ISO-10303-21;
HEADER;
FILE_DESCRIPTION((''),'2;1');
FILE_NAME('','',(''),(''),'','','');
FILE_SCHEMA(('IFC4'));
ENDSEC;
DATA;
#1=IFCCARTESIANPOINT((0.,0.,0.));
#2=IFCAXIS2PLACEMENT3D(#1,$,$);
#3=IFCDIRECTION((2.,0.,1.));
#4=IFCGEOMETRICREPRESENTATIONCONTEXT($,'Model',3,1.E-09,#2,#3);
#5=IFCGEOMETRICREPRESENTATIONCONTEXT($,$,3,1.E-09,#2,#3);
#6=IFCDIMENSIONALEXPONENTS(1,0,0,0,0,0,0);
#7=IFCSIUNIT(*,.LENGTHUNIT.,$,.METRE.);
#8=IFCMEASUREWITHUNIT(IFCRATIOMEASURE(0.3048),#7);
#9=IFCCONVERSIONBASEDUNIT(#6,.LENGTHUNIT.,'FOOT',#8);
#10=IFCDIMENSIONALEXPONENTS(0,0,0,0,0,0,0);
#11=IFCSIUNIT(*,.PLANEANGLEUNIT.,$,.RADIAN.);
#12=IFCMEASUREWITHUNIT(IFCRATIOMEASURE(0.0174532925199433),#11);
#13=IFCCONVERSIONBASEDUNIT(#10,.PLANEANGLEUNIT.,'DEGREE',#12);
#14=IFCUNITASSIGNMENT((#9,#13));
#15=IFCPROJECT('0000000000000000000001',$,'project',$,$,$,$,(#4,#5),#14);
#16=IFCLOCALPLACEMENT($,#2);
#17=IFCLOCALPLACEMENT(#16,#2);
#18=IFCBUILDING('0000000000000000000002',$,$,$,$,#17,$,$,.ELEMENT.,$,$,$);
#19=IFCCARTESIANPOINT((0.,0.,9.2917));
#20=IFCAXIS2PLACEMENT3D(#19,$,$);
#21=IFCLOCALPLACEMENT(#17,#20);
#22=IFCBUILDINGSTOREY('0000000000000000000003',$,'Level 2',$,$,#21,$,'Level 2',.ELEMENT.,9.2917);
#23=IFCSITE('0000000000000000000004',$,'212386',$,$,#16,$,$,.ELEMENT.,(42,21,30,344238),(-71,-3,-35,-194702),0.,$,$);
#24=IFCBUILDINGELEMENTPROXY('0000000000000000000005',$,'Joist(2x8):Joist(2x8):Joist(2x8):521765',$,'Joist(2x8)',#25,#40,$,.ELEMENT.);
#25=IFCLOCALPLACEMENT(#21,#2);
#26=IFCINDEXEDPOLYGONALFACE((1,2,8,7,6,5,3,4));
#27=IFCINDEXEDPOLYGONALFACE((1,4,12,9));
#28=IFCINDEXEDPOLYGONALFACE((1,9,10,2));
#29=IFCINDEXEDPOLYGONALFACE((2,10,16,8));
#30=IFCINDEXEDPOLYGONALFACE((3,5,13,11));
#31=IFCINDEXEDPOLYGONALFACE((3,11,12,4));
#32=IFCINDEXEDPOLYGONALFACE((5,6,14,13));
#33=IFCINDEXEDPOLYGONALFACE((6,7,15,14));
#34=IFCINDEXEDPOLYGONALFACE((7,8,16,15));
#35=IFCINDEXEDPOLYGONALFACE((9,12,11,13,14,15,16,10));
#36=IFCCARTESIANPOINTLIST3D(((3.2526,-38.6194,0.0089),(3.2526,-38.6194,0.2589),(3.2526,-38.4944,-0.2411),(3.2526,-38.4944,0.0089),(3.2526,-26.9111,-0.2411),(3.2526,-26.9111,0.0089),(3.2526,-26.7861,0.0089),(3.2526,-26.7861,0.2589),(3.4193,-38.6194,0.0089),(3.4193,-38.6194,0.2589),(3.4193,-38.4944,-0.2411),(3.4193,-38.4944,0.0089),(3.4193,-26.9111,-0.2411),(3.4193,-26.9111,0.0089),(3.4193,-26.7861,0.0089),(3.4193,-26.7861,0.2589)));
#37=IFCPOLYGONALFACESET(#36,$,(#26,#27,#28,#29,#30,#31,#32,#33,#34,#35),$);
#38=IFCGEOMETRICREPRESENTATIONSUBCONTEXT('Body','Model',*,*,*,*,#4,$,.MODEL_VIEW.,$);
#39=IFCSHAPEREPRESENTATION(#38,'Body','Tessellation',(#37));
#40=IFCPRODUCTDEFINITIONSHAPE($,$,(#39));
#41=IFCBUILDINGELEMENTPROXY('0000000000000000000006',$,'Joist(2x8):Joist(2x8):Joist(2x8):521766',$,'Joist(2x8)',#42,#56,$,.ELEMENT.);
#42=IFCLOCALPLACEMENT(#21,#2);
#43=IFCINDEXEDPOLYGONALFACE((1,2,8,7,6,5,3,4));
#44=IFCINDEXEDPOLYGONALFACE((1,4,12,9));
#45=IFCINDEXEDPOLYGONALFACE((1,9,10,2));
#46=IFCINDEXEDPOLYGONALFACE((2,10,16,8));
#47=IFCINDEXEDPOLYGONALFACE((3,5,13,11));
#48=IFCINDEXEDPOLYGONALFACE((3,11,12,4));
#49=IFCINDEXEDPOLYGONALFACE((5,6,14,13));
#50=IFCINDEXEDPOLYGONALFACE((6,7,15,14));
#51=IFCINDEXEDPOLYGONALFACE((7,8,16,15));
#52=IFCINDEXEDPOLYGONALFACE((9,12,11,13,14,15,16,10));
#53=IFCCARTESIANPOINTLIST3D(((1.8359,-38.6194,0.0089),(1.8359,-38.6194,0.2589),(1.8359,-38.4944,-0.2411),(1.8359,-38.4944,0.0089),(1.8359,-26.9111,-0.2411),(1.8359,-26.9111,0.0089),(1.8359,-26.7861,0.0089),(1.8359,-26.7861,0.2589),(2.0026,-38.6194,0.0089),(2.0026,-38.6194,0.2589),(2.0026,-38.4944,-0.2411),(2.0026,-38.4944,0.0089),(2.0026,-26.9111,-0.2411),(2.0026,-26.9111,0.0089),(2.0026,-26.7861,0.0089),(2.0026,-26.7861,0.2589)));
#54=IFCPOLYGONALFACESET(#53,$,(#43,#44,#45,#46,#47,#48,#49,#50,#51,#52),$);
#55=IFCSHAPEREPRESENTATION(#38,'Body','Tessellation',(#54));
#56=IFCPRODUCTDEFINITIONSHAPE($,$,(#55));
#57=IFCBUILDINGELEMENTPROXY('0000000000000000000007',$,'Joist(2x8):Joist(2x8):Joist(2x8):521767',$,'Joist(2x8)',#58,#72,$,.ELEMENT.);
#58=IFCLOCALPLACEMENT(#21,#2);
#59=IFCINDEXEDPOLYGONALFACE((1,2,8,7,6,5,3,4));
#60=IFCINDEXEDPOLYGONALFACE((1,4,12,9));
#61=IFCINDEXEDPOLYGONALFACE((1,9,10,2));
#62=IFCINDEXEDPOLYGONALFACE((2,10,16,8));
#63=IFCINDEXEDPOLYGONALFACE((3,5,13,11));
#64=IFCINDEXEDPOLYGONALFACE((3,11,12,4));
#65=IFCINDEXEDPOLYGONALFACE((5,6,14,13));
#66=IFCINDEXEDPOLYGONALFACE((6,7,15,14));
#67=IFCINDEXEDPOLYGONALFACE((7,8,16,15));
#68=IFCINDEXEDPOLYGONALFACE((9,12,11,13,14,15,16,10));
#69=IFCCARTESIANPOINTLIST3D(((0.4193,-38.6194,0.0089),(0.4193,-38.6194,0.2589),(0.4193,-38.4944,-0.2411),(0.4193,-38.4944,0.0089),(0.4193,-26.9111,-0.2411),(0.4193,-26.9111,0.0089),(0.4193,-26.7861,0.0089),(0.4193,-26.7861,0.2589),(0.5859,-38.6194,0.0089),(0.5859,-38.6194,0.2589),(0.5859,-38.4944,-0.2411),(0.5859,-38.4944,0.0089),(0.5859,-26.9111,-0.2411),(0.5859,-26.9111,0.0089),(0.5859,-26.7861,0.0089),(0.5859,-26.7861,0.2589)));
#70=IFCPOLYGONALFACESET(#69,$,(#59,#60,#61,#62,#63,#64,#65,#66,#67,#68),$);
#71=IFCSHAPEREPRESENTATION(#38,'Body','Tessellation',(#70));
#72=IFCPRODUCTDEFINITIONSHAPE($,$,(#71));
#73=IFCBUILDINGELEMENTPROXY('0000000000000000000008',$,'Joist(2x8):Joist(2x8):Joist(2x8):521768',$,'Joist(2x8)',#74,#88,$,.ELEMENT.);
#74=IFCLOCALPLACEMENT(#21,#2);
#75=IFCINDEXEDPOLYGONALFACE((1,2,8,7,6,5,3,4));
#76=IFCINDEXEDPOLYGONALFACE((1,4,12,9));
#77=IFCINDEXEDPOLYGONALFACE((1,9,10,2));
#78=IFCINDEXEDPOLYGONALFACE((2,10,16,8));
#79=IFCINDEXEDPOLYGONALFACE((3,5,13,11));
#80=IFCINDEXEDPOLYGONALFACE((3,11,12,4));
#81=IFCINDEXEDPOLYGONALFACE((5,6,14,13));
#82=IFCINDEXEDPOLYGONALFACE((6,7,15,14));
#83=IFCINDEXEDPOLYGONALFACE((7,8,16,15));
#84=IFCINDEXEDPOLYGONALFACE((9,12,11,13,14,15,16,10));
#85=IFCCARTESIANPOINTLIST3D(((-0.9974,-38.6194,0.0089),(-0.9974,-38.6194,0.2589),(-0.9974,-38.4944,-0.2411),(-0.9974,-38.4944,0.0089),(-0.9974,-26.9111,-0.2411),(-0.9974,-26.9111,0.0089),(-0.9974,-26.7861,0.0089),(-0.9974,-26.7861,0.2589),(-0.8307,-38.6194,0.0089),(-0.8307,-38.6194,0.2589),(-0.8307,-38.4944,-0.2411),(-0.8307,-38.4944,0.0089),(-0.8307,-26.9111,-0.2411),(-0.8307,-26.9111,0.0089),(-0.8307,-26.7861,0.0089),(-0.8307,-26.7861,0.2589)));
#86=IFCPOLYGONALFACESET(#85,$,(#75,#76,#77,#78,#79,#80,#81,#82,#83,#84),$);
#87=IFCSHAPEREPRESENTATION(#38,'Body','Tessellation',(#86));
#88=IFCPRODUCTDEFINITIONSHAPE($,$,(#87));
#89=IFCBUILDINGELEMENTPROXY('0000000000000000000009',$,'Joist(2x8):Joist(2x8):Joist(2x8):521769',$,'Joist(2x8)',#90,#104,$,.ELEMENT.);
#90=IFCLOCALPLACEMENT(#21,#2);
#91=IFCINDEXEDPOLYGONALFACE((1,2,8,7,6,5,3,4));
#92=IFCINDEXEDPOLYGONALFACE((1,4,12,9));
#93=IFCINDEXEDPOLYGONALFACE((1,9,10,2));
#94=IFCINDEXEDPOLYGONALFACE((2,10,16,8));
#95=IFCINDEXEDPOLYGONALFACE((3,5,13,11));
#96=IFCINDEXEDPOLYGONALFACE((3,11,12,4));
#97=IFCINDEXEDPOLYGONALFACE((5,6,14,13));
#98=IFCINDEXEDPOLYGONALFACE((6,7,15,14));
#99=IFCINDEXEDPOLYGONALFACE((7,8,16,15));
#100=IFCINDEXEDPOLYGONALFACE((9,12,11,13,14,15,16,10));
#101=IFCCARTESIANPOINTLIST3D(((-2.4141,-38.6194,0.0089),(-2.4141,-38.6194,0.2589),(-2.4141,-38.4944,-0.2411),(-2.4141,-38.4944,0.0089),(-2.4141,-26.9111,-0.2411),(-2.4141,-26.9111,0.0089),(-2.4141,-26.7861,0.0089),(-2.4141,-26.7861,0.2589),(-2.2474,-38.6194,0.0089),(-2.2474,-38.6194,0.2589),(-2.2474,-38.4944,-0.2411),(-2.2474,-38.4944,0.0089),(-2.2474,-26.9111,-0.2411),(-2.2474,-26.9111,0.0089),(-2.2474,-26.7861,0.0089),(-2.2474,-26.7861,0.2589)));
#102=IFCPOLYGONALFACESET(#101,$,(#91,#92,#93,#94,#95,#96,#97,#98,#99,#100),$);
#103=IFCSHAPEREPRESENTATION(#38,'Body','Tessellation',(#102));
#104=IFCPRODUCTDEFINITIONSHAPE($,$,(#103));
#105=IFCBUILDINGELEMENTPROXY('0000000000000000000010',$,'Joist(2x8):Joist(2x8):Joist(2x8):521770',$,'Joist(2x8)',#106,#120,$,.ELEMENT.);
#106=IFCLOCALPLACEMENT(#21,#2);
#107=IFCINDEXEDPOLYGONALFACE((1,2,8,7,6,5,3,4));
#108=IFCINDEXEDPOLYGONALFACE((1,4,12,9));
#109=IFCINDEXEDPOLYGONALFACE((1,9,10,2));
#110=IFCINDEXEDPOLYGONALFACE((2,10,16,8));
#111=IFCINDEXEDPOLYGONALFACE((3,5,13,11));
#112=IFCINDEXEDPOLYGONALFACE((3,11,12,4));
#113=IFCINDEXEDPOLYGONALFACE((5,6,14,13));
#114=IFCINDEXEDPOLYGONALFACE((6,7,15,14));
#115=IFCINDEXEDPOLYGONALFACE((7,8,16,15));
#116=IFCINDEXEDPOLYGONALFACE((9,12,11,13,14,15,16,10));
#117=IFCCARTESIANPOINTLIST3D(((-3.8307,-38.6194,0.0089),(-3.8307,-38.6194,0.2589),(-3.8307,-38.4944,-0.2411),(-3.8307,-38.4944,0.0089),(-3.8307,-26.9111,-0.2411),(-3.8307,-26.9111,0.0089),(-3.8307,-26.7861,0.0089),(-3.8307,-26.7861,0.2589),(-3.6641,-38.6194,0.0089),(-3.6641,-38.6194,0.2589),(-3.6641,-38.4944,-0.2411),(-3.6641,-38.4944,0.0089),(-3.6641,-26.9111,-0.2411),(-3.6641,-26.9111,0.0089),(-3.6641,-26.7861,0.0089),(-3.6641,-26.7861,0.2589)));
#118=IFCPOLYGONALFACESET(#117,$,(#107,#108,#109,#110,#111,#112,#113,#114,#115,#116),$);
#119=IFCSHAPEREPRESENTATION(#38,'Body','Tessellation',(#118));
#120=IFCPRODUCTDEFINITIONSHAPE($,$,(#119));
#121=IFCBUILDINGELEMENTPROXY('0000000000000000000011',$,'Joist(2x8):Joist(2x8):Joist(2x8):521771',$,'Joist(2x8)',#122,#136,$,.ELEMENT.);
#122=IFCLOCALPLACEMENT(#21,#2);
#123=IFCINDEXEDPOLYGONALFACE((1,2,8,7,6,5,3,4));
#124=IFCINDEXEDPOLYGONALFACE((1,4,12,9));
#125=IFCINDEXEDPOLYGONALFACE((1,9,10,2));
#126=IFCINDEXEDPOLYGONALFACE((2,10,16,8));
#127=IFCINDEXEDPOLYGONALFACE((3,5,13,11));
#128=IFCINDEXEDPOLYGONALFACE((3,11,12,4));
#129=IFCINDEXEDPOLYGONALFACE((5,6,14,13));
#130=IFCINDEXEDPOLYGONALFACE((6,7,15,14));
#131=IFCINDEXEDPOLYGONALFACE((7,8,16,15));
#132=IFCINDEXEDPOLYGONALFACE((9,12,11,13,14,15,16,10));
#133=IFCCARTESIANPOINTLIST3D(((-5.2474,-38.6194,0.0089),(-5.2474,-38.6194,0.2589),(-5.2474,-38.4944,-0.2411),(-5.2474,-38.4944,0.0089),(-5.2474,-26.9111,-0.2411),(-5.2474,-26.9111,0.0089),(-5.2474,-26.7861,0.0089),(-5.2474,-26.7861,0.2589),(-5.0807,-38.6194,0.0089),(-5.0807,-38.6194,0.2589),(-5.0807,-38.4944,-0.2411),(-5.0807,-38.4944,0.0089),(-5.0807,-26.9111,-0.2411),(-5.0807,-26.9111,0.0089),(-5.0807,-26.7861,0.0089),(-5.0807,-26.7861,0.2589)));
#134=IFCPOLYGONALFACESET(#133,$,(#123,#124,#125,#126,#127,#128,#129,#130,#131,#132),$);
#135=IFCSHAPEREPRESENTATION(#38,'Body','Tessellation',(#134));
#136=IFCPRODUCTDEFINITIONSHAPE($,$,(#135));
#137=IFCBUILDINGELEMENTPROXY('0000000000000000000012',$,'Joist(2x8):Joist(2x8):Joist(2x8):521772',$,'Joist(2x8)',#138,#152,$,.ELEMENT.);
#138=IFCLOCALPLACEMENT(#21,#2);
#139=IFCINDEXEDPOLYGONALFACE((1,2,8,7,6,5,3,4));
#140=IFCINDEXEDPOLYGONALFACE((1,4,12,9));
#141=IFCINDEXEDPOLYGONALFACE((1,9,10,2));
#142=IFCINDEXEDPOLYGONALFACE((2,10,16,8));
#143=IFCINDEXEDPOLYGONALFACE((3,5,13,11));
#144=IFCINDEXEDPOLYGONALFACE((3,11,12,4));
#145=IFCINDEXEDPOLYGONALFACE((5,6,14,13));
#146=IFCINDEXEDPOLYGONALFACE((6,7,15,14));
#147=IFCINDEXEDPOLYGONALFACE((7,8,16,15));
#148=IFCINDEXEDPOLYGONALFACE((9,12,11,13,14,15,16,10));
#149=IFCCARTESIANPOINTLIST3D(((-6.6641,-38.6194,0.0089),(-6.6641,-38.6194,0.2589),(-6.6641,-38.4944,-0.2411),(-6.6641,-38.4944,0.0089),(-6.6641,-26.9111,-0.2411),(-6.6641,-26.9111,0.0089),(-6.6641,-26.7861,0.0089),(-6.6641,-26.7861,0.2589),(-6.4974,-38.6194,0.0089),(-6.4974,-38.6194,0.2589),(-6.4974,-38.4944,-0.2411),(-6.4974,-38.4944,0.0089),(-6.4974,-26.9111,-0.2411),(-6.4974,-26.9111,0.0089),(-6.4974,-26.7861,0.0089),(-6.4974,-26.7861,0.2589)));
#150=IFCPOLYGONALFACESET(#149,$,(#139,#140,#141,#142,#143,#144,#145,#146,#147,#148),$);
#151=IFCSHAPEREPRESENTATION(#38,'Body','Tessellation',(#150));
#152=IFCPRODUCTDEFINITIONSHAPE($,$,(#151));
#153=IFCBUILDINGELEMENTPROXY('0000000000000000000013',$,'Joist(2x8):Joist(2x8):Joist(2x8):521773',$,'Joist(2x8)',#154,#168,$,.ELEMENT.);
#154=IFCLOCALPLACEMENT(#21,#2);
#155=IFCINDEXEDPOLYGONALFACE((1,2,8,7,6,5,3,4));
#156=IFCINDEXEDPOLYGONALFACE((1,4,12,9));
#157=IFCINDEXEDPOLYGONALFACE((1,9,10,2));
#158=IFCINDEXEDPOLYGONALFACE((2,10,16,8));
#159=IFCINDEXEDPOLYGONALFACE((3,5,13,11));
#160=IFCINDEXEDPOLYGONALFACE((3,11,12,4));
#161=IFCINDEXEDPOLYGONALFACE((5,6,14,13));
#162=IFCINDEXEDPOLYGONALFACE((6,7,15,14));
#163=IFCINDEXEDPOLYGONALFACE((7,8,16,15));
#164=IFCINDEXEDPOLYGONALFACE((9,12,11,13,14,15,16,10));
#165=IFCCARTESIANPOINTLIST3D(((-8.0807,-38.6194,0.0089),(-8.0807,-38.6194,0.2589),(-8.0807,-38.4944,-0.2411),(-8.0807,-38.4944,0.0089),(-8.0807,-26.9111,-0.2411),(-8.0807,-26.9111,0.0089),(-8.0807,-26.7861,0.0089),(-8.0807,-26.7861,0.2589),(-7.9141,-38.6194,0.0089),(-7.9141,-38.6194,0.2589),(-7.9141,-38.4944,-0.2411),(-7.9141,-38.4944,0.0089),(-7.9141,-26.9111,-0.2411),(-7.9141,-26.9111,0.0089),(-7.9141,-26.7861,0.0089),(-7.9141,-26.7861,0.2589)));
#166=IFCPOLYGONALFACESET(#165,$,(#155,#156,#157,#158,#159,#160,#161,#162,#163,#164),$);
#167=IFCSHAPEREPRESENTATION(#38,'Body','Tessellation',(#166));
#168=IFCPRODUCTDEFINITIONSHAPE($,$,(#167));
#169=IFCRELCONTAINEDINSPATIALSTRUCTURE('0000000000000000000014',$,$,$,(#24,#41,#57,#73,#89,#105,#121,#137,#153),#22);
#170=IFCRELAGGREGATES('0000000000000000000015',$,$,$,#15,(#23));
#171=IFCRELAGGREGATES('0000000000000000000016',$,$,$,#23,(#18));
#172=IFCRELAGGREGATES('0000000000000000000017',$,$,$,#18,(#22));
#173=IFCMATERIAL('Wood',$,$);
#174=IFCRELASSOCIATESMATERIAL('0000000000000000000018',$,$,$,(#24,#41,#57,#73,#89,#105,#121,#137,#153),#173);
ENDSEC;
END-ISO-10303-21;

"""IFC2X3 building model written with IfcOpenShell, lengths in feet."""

from ifc_helpers import new_model, entity, si_unit, converted_unit, direction, frame, origin, place, context, subcontext, project, spatial, polyline, outline, extrude, source, transform, mapped, material, element, save


model = new_model("IFC2X3")

# Units and contexts
model_context = context("Model", 3, precision=1e-09, world=origin(), true_north=direction((2.0, 0.0, 1.0)))
context_of_model = context(None, 3, precision=1e-09, world=origin(), true_north=direction((2.0, 0.0, 1.0)))
body_context = subcontext(model_context, "Body", "Model", "MODEL_VIEW")
ifc_project = project(units=[converted_unit("LENGTHUNIT", "FOOT", entity("IfcRatioMeasure", 0.3048), si_unit("LENGTHUNIT", "METRE"), dimensions=[1, 0, 0, 0, 0, 0, 0]), converted_unit("PLANEANGLEUNIT", "DEGREE", entity("IfcRatioMeasure", 0.0174532925199433), si_unit("PLANEANGLEUNIT", "RADIAN"), dimensions=[0, 0, 0, 0, 0, 0, 0])], contexts=[model_context, context_of_model])

# Site, building, storey
site_placement = place(None, origin())
site = spatial("IfcSite", under=ifc_project, at=site_placement, Name="212386", CompositionType="ELEMENT", RefLatitude=(42, 21, 30, 344238), RefLongitude=(-71, -3, -35, -194702), RefElevation=0.0)
building_placement = place(site_placement, origin())
building = spatial("IfcBuilding", under=site, at=building_placement, CompositionType="ELEMENT")
storey_placement = place(building_placement, frame((0.0, 0.0, 9.2917)))
storey = spatial("IfcBuildingStorey", under=building, at=storey_placement, Name="Level 2", LongName="Level 2", CompositionType="ELEMENT", Elevation=9.2917)

# Building element proxies
ifc_material = material(Name="Wood")
shared_shape_1 = source(origin(), body_context, "Body", "SweptSolid", [
    extrude(outline(polyline([(-0.25, -5.9167), (0.0, -5.9167), (0.0, -5.7917), (0.25, -5.7917), (0.25, 5.7917), (0.0, 5.7917), (0.0, 5.9167), (-0.25, 5.9167), (-0.25, -5.9167)])), frame((3.2526, -32.7027, 9.3006), z_axis=(1.0, 0.0, 0.0), x_axis=(0.0, 0.0, -1.0)), (0.0, 0.0, 1.0), 0.1667),
])
proxy_1_placement = place(storey_placement, frame((0.0, 0.0, -9.2917)))
element("IfcBuildingElementProxy", 1, at=proxy_1_placement, inside=storey, material=ifc_material, Name="Joist(2x8):Joist(2x8):Joist(2x8):521765", ObjectType="Joist(2x8)", CompositionType="ELEMENT", context=body_context, shape_type="MappedRepresentation", body=[
    mapped(shared_shape_1, transform((0.0, 0.0, 0.0), scale=1.0)),
])
shared_shape_2 = source(origin(), body_context, "Body", "SweptSolid", [
    extrude(outline(polyline([(-0.25, -5.9167), (0.0, -5.9167), (0.0, -5.7917), (0.25, -5.7917), (0.25, 5.7917), (0.0, 5.7917), (0.0, 5.9167), (-0.25, 5.9167), (-0.25, -5.9167)])), frame((1.8359, -32.7027, 9.3006), z_axis=(1.0, 0.0, 0.0), x_axis=(0.0, 0.0, -1.0)), (0.0, 0.0, 1.0), 0.1667),
])
proxy_2_placement = place(storey_placement, frame((0.0, 0.0, -9.2917)))
element("IfcBuildingElementProxy", 2, at=proxy_2_placement, inside=storey, material=ifc_material, Name="Joist(2x8):Joist(2x8):Joist(2x8):521766", ObjectType="Joist(2x8)", CompositionType="ELEMENT", context=body_context, shape_type="MappedRepresentation", body=[
    mapped(shared_shape_2, transform((0.0, 0.0, 0.0), scale=1.0)),
])
shared_shape_3 = source(origin(), body_context, "Body", "SweptSolid", [
    extrude(outline(polyline([(-0.25, -5.9167), (0.0, -5.9167), (0.0, -5.7917), (0.25, -5.7917), (0.25, 5.7917), (0.0, 5.7917), (0.0, 5.9167), (-0.25, 5.9167), (-0.25, -5.9167)])), frame((0.4193, -32.7027, 9.3006), z_axis=(1.0, 0.0, 0.0), x_axis=(0.0, 0.0, -1.0)), (0.0, 0.0, 1.0), 0.1667),
])
proxy_3_placement = place(storey_placement, frame((0.0, 0.0, -9.2917)))
element("IfcBuildingElementProxy", 3, at=proxy_3_placement, inside=storey, material=ifc_material, Name="Joist(2x8):Joist(2x8):Joist(2x8):521767", ObjectType="Joist(2x8)", CompositionType="ELEMENT", context=body_context, shape_type="MappedRepresentation", body=[
    mapped(shared_shape_3, transform((0.0, 0.0, 0.0), scale=1.0)),
])
shared_shape_4 = source(origin(), body_context, "Body", "SweptSolid", [
    extrude(outline(polyline([(-0.25, -5.9167), (0.0, -5.9167), (0.0, -5.7917), (0.25, -5.7917), (0.25, 5.7917), (0.0, 5.7917), (0.0, 5.9167), (-0.25, 5.9167), (-0.25, -5.9167)])), frame((-0.9974, -32.7027, 9.3006), z_axis=(1.0, 0.0, 0.0), x_axis=(0.0, 0.0, -1.0)), (0.0, 0.0, 1.0), 0.1667),
])
proxy_4_placement = place(storey_placement, frame((0.0, 0.0, -9.2917)))
element("IfcBuildingElementProxy", 4, at=proxy_4_placement, inside=storey, material=ifc_material, Name="Joist(2x8):Joist(2x8):Joist(2x8):521768", ObjectType="Joist(2x8)", CompositionType="ELEMENT", context=body_context, shape_type="MappedRepresentation", body=[
    mapped(shared_shape_4, transform((0.0, 0.0, 0.0), scale=1.0)),
])
shared_shape_5 = source(origin(), body_context, "Body", "SweptSolid", [
    extrude(outline(polyline([(-0.25, -5.9167), (0.0, -5.9167), (0.0, -5.7917), (0.25, -5.7917), (0.25, 5.7917), (0.0, 5.7917), (0.0, 5.9167), (-0.25, 5.9167), (-0.25, -5.9167)])), frame((-2.4141, -32.7027, 9.3006), z_axis=(1.0, 0.0, 0.0), x_axis=(0.0, 0.0, -1.0)), (0.0, 0.0, 1.0), 0.1667),
])
proxy_5_placement = place(storey_placement, frame((0.0, 0.0, -9.2917)))
element("IfcBuildingElementProxy", 5, at=proxy_5_placement, inside=storey, material=ifc_material, Name="Joist(2x8):Joist(2x8):Joist(2x8):521769", ObjectType="Joist(2x8)", CompositionType="ELEMENT", context=body_context, shape_type="MappedRepresentation", body=[
    mapped(shared_shape_5, transform((0.0, 0.0, 0.0), scale=1.0)),
])
shared_shape_6 = source(origin(), body_context, "Body", "SweptSolid", [
    extrude(outline(polyline([(-0.25, -5.9167), (0.0, -5.9167), (0.0, -5.7917), (0.25, -5.7917), (0.25, 5.7917), (0.0, 5.7917), (0.0, 5.9167), (-0.25, 5.9167), (-0.25, -5.9167)])), frame((-3.8307, -32.7027, 9.3006), z_axis=(1.0, 0.0, 0.0), x_axis=(0.0, 0.0, -1.0)), (0.0, 0.0, 1.0), 0.1667),
])
proxy_6_placement = place(storey_placement, frame((0.0, 0.0, -9.2917)))
element("IfcBuildingElementProxy", 6, at=proxy_6_placement, inside=storey, material=ifc_material, Name="Joist(2x8):Joist(2x8):Joist(2x8):521770", ObjectType="Joist(2x8)", CompositionType="ELEMENT", context=body_context, shape_type="MappedRepresentation", body=[
    mapped(shared_shape_6, transform((0.0, 0.0, 0.0), scale=1.0)),
])
shared_shape_7 = source(origin(), body_context, "Body", "SweptSolid", [
    extrude(outline(polyline([(-0.25, -5.9167), (0.0, -5.9167), (0.0, -5.7917), (0.25, -5.7917), (0.25, 5.7917), (0.0, 5.7917), (0.0, 5.9167), (-0.25, 5.9167), (-0.25, -5.9167)])), frame((-5.2474, -32.7027, 9.3006), z_axis=(1.0, 0.0, 0.0), x_axis=(0.0, 0.0, -1.0)), (0.0, 0.0, 1.0), 0.1667),
])
proxy_7_placement = place(storey_placement, frame((0.0, 0.0, -9.2917)))
element("IfcBuildingElementProxy", 7, at=proxy_7_placement, inside=storey, material=ifc_material, Name="Joist(2x8):Joist(2x8):Joist(2x8):521771", ObjectType="Joist(2x8)", CompositionType="ELEMENT", context=body_context, shape_type="MappedRepresentation", body=[
    mapped(shared_shape_7, transform((0.0, 0.0, 0.0), scale=1.0)),
])
shared_shape_8 = source(origin(), body_context, "Body", "SweptSolid", [
    extrude(outline(polyline([(-0.25, -5.9167), (0.0, -5.9167), (0.0, -5.7917), (0.25, -5.7917), (0.25, 5.7917), (0.0, 5.7917), (0.0, 5.9167), (-0.25, 5.9167), (-0.25, -5.9167)])), frame((-6.6641, -32.7027, 9.3006), z_axis=(1.0, 0.0, 0.0), x_axis=(0.0, 0.0, -1.0)), (0.0, 0.0, 1.0), 0.1667),
])
proxy_8_placement = place(storey_placement, frame((0.0, 0.0, -9.2917)))
element("IfcBuildingElementProxy", 8, at=proxy_8_placement, inside=storey, material=ifc_material, Name="Joist(2x8):Joist(2x8):Joist(2x8):521772", ObjectType="Joist(2x8)", CompositionType="ELEMENT", context=body_context, shape_type="MappedRepresentation", body=[
    mapped(shared_shape_8, transform((0.0, 0.0, 0.0), scale=1.0)),
])
shared_shape_9 = source(origin(), body_context, "Body", "SweptSolid", [
    extrude(outline(polyline([(-0.25, -5.9167), (0.0, -5.9167), (0.0, -5.7917), (0.25, -5.7917), (0.25, 5.7917), (0.0, 5.7917), (0.0, 5.9167), (-0.25, 5.9167), (-0.25, -5.9167)])), frame((-8.0807, -32.7027, 9.3006), z_axis=(1.0, 0.0, 0.0), x_axis=(0.0, 0.0, -1.0)), (0.0, 0.0, 1.0), 0.1667),
])
proxy_9_placement = place(storey_placement, frame((0.0, 0.0, -9.2917)))
element("IfcBuildingElementProxy", 9, at=proxy_9_placement, inside=storey, material=ifc_material, Name="Joist(2x8):Joist(2x8):Joist(2x8):521773", ObjectType="Joist(2x8)", CompositionType="ELEMENT", context=body_context, shape_type="MappedRepresentation", body=[
    mapped(shared_shape_9, transform((0.0, 0.0, 0.0), scale=1.0)),
])

save(model, "model.ifc")
